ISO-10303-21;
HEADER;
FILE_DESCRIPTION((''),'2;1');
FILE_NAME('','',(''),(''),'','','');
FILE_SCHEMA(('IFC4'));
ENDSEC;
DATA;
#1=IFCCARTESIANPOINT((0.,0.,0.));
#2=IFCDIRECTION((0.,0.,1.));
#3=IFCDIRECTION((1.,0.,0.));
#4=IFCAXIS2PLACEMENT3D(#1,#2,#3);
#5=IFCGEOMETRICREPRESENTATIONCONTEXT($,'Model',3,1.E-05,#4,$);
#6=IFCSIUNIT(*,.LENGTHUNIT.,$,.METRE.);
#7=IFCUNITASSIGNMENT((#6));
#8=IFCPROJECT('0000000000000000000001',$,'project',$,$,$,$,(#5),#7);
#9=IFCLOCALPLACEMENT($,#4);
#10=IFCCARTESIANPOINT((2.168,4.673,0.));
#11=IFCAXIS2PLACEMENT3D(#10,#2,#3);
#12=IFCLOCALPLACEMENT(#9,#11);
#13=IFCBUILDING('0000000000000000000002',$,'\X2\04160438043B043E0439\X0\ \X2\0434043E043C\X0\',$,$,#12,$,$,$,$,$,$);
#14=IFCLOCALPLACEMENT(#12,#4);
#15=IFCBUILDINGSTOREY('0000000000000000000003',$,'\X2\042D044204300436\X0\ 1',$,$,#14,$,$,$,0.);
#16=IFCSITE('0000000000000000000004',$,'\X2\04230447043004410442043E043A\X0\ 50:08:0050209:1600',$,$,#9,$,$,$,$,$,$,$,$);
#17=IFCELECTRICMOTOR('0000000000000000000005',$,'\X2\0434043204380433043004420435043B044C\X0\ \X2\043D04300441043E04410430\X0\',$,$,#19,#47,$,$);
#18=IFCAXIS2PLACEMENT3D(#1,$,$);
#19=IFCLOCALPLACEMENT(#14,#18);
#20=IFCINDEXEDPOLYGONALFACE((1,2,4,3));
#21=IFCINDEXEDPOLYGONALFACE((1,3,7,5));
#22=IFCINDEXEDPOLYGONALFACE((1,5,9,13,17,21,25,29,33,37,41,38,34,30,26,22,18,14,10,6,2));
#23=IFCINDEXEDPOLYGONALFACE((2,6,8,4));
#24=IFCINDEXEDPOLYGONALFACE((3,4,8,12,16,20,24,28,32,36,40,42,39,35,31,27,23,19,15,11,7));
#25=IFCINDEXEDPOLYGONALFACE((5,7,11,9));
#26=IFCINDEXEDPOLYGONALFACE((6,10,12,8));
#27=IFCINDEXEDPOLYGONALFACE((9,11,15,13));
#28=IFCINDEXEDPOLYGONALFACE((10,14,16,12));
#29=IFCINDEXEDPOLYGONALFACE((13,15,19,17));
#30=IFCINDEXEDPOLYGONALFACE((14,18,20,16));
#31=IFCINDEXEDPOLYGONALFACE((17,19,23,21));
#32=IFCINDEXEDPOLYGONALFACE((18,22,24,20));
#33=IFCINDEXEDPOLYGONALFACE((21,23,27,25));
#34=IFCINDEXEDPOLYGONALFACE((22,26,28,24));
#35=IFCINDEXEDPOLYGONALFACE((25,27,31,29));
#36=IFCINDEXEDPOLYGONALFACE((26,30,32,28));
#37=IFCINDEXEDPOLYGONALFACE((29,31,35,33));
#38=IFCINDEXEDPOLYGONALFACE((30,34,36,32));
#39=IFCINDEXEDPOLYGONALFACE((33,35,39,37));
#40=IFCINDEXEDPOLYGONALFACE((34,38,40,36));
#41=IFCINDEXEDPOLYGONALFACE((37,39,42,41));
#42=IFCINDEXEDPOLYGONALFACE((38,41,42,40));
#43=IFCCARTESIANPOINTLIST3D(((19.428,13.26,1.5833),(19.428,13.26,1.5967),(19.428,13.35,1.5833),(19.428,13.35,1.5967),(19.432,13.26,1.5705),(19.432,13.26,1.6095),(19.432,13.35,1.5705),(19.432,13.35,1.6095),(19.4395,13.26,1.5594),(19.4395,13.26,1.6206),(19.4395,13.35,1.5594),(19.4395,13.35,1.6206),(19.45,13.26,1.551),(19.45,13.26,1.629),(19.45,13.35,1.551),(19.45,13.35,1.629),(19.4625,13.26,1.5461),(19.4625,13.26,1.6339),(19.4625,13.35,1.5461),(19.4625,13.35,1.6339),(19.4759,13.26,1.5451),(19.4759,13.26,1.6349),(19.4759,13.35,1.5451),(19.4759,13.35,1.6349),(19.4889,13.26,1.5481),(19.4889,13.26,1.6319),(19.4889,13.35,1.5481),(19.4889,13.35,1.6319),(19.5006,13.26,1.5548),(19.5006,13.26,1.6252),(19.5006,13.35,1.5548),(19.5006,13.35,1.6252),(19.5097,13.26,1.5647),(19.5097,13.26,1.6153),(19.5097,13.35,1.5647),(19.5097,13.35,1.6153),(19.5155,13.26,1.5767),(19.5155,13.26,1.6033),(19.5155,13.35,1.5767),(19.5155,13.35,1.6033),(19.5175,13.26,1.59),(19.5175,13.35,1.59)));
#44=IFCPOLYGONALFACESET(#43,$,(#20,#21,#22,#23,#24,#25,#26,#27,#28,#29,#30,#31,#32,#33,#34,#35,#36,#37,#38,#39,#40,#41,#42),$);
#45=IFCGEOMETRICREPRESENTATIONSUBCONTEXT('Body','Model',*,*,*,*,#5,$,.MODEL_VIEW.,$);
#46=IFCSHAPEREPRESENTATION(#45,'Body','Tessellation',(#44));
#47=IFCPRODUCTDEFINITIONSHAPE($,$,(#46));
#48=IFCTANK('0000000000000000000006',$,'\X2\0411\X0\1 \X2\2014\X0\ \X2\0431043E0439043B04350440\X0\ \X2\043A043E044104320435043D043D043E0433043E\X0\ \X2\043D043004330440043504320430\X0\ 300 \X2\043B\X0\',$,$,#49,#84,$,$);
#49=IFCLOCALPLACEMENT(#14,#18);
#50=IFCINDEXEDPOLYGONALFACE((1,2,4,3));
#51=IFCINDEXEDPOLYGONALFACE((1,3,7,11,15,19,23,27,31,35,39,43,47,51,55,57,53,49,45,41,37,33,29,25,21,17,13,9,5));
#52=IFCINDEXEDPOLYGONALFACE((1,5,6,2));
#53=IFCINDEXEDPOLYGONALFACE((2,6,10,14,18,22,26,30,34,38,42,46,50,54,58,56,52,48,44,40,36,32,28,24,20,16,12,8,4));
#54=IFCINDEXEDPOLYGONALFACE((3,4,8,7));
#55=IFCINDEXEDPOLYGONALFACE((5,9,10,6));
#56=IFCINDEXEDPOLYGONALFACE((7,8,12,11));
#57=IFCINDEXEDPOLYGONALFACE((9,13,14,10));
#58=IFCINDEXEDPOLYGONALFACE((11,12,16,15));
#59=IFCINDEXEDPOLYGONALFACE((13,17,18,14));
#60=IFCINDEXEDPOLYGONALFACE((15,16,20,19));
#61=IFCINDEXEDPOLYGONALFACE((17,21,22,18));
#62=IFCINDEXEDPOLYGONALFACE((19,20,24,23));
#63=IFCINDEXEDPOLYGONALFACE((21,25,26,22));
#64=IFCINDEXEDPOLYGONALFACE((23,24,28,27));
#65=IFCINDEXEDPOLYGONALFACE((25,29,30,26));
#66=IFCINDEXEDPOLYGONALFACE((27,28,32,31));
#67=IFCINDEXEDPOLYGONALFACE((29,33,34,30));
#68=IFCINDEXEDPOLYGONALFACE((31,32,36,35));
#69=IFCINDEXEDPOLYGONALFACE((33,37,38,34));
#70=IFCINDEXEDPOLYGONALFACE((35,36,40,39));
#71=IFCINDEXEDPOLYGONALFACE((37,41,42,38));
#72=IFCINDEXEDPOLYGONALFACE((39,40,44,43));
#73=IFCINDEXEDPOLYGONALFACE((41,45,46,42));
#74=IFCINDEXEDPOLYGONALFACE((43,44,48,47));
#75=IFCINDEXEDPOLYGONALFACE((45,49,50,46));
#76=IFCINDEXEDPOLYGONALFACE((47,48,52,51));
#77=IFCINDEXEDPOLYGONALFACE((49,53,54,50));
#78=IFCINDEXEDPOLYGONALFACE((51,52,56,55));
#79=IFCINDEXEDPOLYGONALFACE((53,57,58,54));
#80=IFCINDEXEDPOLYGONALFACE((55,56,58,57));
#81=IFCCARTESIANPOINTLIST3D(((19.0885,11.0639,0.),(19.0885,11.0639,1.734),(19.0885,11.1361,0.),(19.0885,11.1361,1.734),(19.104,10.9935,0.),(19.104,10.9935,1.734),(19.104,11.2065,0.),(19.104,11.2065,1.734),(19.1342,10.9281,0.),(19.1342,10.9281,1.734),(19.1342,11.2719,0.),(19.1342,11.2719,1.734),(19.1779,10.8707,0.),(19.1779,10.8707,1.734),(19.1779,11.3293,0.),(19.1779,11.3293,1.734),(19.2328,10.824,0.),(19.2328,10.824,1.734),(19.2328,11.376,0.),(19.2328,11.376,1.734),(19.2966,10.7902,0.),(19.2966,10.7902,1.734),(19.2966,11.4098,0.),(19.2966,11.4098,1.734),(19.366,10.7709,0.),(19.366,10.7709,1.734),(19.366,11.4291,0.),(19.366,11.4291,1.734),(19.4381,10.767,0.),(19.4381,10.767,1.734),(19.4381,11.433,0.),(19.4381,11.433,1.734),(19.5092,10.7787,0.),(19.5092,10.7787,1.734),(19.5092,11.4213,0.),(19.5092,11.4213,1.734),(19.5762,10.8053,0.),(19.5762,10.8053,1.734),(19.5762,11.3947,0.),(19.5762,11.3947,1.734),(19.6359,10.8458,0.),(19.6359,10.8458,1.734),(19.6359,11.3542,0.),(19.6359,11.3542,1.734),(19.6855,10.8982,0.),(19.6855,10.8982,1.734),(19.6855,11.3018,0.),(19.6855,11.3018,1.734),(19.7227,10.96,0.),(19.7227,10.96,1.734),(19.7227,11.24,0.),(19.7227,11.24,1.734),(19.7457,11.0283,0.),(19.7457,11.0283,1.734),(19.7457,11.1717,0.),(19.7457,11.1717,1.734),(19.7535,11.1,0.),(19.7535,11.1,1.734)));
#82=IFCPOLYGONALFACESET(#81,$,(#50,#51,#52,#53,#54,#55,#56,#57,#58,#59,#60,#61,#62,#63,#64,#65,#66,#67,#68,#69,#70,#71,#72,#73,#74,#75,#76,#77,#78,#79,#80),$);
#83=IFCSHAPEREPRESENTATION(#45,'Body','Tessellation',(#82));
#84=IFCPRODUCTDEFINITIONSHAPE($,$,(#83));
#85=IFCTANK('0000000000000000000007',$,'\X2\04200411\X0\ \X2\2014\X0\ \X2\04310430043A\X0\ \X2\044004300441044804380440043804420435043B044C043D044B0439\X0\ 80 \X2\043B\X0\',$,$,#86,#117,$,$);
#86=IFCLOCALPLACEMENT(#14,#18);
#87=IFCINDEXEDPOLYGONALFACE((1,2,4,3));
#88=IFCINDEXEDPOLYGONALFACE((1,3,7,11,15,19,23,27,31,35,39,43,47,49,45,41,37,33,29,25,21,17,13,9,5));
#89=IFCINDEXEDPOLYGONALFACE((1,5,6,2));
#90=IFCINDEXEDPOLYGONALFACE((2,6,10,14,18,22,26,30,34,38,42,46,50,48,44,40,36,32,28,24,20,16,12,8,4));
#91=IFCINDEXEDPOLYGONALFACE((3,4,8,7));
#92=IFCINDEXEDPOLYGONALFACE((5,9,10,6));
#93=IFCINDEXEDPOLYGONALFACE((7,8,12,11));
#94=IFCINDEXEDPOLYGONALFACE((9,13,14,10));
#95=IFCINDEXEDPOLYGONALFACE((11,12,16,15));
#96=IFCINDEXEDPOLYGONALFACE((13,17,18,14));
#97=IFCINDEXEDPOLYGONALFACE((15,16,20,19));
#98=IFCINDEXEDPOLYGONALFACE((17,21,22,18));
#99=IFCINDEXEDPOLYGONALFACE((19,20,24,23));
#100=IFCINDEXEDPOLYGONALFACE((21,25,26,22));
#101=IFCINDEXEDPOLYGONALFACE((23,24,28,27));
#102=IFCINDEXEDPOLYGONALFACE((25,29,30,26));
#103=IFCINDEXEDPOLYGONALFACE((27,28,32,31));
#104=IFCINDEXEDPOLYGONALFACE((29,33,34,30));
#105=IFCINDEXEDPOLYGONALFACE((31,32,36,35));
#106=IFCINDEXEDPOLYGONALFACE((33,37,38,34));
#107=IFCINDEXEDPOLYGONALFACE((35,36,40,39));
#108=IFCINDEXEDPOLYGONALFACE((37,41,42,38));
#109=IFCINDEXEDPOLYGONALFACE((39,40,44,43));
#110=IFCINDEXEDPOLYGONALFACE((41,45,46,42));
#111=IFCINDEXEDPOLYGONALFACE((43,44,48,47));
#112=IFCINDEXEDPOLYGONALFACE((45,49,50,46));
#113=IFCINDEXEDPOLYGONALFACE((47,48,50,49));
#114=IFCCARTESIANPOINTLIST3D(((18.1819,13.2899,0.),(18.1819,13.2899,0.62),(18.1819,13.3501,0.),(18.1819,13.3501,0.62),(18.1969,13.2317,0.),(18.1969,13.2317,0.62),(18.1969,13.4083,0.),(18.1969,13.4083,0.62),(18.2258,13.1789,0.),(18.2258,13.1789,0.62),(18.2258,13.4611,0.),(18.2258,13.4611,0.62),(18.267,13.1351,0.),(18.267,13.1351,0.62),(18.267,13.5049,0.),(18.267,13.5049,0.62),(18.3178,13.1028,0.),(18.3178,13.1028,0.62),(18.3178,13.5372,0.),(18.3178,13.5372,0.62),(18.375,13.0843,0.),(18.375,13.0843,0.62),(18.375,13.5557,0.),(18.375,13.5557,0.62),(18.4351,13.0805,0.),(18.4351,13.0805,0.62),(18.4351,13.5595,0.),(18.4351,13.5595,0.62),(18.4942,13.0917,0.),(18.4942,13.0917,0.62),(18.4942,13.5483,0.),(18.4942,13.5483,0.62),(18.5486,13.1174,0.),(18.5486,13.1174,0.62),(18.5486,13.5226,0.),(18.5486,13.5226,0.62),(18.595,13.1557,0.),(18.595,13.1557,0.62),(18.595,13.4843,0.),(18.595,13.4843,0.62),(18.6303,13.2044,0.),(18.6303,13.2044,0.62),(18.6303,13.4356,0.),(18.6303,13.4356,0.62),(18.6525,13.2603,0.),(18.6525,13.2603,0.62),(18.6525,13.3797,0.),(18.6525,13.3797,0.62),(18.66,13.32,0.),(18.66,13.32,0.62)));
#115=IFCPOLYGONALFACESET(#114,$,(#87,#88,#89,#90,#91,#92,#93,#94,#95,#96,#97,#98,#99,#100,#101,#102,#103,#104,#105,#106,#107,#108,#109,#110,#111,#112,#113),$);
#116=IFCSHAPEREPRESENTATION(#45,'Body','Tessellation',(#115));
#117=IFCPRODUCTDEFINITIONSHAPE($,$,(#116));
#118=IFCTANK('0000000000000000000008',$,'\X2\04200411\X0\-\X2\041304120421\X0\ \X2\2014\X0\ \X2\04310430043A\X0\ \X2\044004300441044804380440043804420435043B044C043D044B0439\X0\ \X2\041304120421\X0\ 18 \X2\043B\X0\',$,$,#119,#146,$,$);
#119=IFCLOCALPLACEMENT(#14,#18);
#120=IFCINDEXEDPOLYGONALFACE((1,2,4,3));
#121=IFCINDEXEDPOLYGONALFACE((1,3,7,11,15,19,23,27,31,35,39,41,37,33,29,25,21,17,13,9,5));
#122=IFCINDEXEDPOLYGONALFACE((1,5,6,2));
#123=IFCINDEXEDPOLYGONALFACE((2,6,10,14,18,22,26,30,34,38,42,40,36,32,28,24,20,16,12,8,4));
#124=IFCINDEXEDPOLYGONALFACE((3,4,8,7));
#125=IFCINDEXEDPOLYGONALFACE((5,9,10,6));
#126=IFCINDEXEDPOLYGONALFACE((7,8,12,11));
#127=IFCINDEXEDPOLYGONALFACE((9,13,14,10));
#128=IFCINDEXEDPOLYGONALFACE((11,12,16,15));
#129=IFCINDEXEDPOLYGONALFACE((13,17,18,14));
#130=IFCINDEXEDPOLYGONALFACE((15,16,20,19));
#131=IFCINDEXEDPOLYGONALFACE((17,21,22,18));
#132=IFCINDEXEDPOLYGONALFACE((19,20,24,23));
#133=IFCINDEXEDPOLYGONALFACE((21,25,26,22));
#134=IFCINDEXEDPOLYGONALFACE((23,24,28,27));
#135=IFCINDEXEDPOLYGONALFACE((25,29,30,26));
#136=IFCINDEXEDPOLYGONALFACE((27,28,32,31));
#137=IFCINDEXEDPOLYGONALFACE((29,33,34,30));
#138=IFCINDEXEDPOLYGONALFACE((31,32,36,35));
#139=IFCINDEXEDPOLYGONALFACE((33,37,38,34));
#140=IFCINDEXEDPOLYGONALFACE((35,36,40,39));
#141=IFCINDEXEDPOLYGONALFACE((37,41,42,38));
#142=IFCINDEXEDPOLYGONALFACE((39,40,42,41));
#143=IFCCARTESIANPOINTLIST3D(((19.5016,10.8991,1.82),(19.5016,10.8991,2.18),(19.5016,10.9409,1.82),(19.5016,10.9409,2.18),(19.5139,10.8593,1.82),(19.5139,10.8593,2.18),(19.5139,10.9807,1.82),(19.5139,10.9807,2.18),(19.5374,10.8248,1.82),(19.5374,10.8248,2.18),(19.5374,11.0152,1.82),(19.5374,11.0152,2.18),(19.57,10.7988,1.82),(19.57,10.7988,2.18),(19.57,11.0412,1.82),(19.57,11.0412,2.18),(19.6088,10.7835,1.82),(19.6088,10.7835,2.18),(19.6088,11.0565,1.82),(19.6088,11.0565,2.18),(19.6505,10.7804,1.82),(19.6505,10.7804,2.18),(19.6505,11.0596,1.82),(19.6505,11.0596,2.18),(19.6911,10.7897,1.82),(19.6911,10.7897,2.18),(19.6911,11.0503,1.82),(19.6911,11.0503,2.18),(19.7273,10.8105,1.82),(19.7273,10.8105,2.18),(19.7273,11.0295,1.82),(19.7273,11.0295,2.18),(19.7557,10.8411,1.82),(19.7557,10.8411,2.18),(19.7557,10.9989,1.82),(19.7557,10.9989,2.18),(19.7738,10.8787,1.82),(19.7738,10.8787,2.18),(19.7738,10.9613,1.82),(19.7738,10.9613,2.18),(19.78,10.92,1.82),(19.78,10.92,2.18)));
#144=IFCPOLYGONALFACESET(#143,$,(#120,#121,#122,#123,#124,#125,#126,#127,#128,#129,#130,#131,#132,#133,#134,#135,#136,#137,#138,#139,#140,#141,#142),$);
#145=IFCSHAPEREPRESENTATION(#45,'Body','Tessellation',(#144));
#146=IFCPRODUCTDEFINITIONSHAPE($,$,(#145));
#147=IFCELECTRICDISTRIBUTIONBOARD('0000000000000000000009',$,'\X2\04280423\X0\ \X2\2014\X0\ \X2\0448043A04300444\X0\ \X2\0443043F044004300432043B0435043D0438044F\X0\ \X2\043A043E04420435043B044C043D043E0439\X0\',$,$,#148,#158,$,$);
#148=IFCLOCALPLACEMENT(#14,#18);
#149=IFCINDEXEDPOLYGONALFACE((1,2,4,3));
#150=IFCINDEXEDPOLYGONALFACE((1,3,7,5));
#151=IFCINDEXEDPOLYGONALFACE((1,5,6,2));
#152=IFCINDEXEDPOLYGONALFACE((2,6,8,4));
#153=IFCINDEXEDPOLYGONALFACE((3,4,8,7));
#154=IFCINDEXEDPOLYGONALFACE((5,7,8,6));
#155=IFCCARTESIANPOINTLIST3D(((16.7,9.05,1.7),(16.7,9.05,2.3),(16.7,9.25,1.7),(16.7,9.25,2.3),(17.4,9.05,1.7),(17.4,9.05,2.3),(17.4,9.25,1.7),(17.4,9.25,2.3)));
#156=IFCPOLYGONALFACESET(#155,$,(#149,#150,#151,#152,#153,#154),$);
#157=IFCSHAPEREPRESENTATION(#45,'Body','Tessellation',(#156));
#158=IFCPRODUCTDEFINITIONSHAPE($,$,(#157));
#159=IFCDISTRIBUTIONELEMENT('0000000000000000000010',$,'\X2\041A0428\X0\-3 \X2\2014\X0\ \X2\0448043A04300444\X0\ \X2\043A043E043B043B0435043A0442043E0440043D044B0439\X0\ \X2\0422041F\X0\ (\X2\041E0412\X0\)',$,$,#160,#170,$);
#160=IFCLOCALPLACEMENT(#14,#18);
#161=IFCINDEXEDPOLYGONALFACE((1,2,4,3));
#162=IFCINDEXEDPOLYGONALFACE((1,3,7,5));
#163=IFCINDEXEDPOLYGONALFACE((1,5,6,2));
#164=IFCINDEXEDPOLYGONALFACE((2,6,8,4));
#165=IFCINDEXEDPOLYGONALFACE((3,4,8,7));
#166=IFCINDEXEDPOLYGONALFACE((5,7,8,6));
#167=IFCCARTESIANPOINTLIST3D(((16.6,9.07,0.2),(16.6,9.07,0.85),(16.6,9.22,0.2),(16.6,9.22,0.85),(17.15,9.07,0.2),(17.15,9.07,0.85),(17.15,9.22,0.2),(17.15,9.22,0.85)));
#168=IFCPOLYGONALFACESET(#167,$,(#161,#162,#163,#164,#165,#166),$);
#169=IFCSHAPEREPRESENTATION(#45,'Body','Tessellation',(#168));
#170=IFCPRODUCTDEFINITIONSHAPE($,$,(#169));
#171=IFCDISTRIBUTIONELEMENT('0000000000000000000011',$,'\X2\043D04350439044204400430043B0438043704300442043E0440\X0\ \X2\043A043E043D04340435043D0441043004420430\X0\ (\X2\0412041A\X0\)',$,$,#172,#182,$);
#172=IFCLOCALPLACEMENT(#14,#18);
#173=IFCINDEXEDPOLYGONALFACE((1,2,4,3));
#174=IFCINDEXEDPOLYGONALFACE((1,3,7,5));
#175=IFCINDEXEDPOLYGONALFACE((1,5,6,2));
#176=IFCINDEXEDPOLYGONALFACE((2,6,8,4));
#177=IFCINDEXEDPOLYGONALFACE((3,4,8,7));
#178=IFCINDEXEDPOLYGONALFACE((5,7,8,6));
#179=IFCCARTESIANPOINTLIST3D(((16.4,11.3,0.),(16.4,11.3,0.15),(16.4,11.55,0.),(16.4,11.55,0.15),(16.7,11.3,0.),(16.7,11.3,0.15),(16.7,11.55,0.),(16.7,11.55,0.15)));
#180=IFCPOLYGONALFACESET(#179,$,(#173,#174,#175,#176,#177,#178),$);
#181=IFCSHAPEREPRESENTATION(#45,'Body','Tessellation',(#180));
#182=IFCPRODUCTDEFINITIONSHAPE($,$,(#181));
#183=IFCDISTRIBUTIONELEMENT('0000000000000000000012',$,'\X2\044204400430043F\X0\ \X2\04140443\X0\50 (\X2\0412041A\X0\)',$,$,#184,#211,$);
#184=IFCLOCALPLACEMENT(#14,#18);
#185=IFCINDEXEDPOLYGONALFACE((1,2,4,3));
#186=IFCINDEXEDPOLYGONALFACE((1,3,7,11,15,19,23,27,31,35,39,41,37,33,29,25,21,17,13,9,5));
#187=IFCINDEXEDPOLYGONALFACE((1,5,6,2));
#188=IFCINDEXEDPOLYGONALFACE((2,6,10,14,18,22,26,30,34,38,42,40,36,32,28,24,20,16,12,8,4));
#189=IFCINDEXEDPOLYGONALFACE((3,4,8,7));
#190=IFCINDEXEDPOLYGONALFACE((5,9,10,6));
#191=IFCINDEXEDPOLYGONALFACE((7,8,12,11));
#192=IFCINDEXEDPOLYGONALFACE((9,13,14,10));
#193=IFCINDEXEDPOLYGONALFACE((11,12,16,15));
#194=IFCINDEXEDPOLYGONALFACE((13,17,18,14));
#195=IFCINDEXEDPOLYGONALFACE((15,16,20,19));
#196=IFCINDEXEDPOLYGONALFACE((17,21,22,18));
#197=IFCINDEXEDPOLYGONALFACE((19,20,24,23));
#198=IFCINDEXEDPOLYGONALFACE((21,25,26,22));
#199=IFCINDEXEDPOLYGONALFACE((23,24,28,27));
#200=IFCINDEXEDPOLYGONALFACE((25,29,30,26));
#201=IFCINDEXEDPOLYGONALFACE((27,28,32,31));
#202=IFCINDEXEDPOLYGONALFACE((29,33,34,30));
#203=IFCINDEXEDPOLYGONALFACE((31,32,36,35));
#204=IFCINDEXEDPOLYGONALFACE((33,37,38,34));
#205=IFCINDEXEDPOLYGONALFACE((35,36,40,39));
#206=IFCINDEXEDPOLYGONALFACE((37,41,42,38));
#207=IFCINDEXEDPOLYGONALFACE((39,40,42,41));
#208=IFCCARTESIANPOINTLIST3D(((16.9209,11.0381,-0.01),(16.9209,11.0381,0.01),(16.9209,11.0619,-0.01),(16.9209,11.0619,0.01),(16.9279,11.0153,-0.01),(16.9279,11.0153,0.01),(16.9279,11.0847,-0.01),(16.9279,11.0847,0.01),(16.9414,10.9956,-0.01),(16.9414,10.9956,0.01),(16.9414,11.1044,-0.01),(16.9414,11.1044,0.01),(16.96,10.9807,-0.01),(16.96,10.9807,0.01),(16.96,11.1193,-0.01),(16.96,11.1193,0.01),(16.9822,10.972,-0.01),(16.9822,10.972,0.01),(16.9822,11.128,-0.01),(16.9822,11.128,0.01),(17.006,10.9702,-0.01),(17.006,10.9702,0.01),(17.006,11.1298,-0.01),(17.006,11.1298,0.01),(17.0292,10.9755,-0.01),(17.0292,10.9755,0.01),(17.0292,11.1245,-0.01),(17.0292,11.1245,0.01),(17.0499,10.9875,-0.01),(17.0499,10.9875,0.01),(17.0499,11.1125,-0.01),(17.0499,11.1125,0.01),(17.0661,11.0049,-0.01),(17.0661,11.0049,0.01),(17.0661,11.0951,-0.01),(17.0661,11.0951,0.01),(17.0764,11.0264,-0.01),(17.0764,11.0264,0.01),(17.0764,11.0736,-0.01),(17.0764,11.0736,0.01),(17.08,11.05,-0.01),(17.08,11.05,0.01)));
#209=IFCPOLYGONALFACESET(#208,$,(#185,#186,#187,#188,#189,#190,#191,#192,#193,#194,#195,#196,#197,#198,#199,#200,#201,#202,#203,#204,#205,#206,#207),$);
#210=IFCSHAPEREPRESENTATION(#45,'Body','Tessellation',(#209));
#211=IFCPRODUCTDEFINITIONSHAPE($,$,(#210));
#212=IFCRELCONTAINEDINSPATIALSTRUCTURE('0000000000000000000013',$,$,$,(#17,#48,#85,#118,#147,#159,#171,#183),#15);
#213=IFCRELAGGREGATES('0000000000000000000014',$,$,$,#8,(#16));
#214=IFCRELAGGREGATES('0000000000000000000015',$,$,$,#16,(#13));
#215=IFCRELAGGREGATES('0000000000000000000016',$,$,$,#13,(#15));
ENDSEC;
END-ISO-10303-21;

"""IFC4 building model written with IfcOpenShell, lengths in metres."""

from ifc_helpers import new_model, si_unit, frame, frame_2d, origin_with_axes, origin_2d, place, context, subcontext, project, spatial, rectangle, circle, extrude, element, save


model = new_model("IFC4")

# Units and contexts
model_context = context("Model", 3, precision=1e-05, world=origin_with_axes())
body_context = subcontext(model_context, "Body", "Model", "MODEL_VIEW")
ifc_project = project(units=[si_unit("LENGTHUNIT", "METRE")], contexts=[model_context])

# Site, building, storey
site_placement = place(None, origin_with_axes())
site = spatial("IfcSite", under=ifc_project, at=site_placement, Name="Участок 50:08:0050209:1600")
building_placement = place(site_placement, frame((2.168, 4.673, 0.0), z_axis=(0.0, 0.0, 1.0), x_axis=(1.0, 0.0, 0.0)))
building = spatial("IfcBuilding", under=site, at=building_placement, Name="Жилой дом")
storey_placement = place(building_placement, origin_with_axes())
storey = spatial("IfcBuildingStorey", under=building, at=storey_placement, Name="Этаж 1", Elevation=0.0)

# Electric motor
electric_motor_1_placement = place(storey_placement, origin_with_axes())
element("IfcElectricMotor", 1, at=electric_motor_1_placement, inside=storey, Name="двигатель насоса", context=body_context, shape_type="SweptSolid", body=[
    extrude(circle(Radius=0.045, at=origin_2d()), frame((19.4725, 13.35, 1.59), z_axis=(0.0, -1.0, 0.0), x_axis=(1.0, 0.0, 0.0)), (0.0, 0.0, 1.0), 0.09),
])

# Tanks
tank_1_placement = place(storey_placement, origin_with_axes())
element("IfcTank", 2, at=tank_1_placement, inside=storey, Name="Б1 — бойлер косвенного нагрева 300 л", context=body_context, shape_type="SweptSolid", body=[
    extrude(circle(Radius=0.3335, at=origin_2d()), frame((19.42, 11.1, 0.0), z_axis=(0.0, 0.0, 1.0), x_axis=(1.0, 0.0, 0.0)), (0.0, 0.0, 1.0), 1.734),
])
tank_2_placement = place(storey_placement, origin_with_axes())
element("IfcTank", 3, at=tank_2_placement, inside=storey, Name="РБ — бак расширительный 80 л", context=body_context, shape_type="SweptSolid", body=[
    extrude(circle(Radius=0.24, at=origin_2d()), frame((18.42, 13.32, 0.0), z_axis=(0.0, 0.0, 1.0), x_axis=(1.0, 0.0, 0.0)), (0.0, 0.0, 1.0), 0.62),
])
tank_3_placement = place(storey_placement, origin_with_axes())
element("IfcTank", 4, at=tank_3_placement, inside=storey, Name="РБ-ГВС — бак расширительный ГВС 18 л", context=body_context, shape_type="SweptSolid", body=[
    extrude(circle(Radius=0.14, at=origin_2d()), frame((19.64, 10.92, 1.82), z_axis=(0.0, 0.0, 1.0), x_axis=(1.0, 0.0, 0.0)), (0.0, 0.0, 1.0), 0.36),
])

# Electric distribution board
electric_distribution_board_placement = place(storey_placement, origin_with_axes())
element("IfcElectricDistributionBoard", 5, at=electric_distribution_board_placement, inside=storey, Name="ШУ — шкаф управления котельной", context=body_context, shape_type="SweptSolid", body=[
    extrude(rectangle(XDim=0.7, YDim=0.2, at=frame_2d((0.35, 0.1))), frame((16.7, 9.05, 1.7), z_axis=(0.0, 0.0, 1.0), x_axis=(1.0, 0.0, 0.0)), (0.0, 0.0, 1.0), 0.6),
])

# Distribution elements
distribution_element_1_placement = place(storey_placement, origin_with_axes())
element("IfcDistributionElement", 6, at=distribution_element_1_placement, inside=storey, Name="КШ-3 — шкаф коллекторный ТП (ОВ)", context=body_context, shape_type="SweptSolid", body=[
    extrude(rectangle(XDim=0.55, YDim=0.15, at=frame_2d((0.275, 0.075))), frame((16.6, 9.07, 0.2), z_axis=(0.0, 0.0, 1.0), x_axis=(1.0, 0.0, 0.0)), (0.0, 0.0, 1.0), 0.65),
])
distribution_element_2_placement = place(storey_placement, origin_with_axes())
element("IfcDistributionElement", 7, at=distribution_element_2_placement, inside=storey, Name="нейтрализатор конденсата (ВК)", context=body_context, shape_type="SweptSolid", body=[
    extrude(rectangle(XDim=0.3, YDim=0.25, at=frame_2d((0.15, 0.125))), frame((16.4, 11.3, 0.0), z_axis=(0.0, 0.0, 1.0), x_axis=(1.0, 0.0, 0.0)), (0.0, 0.0, 1.0), 0.15),
])
distribution_element_3_placement = place(storey_placement, origin_with_axes())
element("IfcDistributionElement", 8, at=distribution_element_3_placement, inside=storey, Name="трап Ду50 (ВК)", context=body_context, shape_type="SweptSolid", body=[
    extrude(circle(Radius=0.08, at=origin_2d()), frame((17.0, 11.05, -0.01), z_axis=(0.0, 0.0, 1.0), x_axis=(1.0, 0.0, 0.0)), (0.0, 0.0, 1.0), 0.02),
])

save(model, "model.ifc")
